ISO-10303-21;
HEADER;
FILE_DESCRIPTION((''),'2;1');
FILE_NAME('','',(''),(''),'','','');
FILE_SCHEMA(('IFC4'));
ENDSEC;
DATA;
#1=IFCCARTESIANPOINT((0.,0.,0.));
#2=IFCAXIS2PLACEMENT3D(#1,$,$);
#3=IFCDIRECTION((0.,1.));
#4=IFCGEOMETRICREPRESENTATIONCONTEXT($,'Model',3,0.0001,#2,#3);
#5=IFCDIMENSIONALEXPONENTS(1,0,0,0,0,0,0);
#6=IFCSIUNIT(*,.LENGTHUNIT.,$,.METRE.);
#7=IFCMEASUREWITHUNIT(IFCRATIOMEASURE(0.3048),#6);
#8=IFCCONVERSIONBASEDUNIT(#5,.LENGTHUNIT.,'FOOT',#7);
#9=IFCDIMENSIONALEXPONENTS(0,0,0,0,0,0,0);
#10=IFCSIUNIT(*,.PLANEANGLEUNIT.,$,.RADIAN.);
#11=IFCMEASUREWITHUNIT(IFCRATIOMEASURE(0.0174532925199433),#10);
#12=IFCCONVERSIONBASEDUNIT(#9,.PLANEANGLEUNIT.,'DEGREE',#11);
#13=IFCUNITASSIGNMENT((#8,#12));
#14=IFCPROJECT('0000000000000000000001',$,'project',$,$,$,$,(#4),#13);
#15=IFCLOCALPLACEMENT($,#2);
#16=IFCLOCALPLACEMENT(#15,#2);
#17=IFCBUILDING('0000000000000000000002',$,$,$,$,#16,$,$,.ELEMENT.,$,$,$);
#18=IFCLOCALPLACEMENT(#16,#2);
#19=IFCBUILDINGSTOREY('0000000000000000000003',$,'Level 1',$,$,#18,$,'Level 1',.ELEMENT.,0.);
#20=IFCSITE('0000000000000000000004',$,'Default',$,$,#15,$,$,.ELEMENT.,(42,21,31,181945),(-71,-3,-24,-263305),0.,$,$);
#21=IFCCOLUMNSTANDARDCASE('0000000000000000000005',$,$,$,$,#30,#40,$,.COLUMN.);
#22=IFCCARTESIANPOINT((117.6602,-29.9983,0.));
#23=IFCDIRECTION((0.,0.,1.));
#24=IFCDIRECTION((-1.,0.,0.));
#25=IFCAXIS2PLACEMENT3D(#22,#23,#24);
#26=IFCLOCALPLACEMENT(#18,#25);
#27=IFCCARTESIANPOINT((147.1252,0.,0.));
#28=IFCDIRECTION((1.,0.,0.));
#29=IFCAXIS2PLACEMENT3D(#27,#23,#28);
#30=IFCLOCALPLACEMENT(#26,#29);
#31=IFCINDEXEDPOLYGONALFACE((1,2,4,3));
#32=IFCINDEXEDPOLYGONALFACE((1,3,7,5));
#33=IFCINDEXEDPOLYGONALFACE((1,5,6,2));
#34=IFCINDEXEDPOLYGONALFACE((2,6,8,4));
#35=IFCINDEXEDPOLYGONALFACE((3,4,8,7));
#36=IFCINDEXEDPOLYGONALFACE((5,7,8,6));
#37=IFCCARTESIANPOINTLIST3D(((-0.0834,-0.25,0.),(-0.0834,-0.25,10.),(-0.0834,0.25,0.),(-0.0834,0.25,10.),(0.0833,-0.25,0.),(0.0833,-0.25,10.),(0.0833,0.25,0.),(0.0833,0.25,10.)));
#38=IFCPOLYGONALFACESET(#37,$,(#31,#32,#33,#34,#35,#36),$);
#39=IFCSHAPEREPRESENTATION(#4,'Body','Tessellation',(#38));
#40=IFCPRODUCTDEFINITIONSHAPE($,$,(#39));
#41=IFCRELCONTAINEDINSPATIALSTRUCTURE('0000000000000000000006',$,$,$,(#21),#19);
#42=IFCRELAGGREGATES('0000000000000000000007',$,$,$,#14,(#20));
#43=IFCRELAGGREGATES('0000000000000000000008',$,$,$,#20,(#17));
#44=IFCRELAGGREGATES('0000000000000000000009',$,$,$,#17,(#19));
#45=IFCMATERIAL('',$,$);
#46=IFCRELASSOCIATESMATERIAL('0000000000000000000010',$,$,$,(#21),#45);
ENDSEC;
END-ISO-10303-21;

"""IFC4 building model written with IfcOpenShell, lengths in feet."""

from ifc_helpers import new_model, entity, si_unit, converted_unit, direction, frame, origin, place, context, project, spatial, rectangle, extrude, material, element, save


model = new_model("IFC4")

# Units and contexts
model_context = context("Model", 3, precision=0.0001, world=origin(), true_north=direction((0.0, 1.0)))
ifc_project = project(units=[converted_unit("LENGTHUNIT", "FOOT", entity("IfcRatioMeasure", 0.3048), si_unit("LENGTHUNIT", "METRE"), dimensions=[1, 0, 0, 0, 0, 0, 0]), converted_unit("PLANEANGLEUNIT", "DEGREE", entity("IfcRatioMeasure", 0.0174532925199433), si_unit("PLANEANGLEUNIT", "RADIAN"), dimensions=[0, 0, 0, 0, 0, 0, 0])], contexts=[model_context])

# Site, building, storey
site_placement = place(None, origin())
site = spatial("IfcSite", under=ifc_project, at=site_placement, Name="Default", CompositionType="ELEMENT", RefLatitude=(42, 21, 31, 181945), RefLongitude=(-71, -3, -24, -263305), RefElevation=0.0)
building_placement = place(site_placement, origin())
building = spatial("IfcBuilding", under=site, at=building_placement, CompositionType="ELEMENT")
storey_placement = place(building_placement, origin())
storey = spatial("IfcBuildingStorey", under=building, at=storey_placement, Name="Level 1", LongName="Level 1", CompositionType="ELEMENT", Elevation=0.0)

# Column
ifc_material_1 = material(Name="")
placement = place(storey_placement, frame((117.6602, -29.9983, 0.0), z_axis=(0.0, 0.0, 1.0), x_axis=(-1.0, 0.0, 0.0)))
for number, where, z_axis, x_axis in (
    (1, (147.1252, 0.0, 0.0), (0.0, 0.0, 1.0), (1.0, 0.0, 0.0)),
):
    element("IfcColumnStandardCase", number, at=place(placement, frame(where, z_axis=z_axis, x_axis=x_axis)), inside=storey, material=ifc_material_1, PredefinedType="COLUMN", context=model_context, shape_type="SweptSolid", body=[
        extrude(rectangle(XDim=0.1667, YDim=0.5), origin(), (0.0, 0.0, 1.0), 10.0),
    ])

save(model, "model.ifc")
